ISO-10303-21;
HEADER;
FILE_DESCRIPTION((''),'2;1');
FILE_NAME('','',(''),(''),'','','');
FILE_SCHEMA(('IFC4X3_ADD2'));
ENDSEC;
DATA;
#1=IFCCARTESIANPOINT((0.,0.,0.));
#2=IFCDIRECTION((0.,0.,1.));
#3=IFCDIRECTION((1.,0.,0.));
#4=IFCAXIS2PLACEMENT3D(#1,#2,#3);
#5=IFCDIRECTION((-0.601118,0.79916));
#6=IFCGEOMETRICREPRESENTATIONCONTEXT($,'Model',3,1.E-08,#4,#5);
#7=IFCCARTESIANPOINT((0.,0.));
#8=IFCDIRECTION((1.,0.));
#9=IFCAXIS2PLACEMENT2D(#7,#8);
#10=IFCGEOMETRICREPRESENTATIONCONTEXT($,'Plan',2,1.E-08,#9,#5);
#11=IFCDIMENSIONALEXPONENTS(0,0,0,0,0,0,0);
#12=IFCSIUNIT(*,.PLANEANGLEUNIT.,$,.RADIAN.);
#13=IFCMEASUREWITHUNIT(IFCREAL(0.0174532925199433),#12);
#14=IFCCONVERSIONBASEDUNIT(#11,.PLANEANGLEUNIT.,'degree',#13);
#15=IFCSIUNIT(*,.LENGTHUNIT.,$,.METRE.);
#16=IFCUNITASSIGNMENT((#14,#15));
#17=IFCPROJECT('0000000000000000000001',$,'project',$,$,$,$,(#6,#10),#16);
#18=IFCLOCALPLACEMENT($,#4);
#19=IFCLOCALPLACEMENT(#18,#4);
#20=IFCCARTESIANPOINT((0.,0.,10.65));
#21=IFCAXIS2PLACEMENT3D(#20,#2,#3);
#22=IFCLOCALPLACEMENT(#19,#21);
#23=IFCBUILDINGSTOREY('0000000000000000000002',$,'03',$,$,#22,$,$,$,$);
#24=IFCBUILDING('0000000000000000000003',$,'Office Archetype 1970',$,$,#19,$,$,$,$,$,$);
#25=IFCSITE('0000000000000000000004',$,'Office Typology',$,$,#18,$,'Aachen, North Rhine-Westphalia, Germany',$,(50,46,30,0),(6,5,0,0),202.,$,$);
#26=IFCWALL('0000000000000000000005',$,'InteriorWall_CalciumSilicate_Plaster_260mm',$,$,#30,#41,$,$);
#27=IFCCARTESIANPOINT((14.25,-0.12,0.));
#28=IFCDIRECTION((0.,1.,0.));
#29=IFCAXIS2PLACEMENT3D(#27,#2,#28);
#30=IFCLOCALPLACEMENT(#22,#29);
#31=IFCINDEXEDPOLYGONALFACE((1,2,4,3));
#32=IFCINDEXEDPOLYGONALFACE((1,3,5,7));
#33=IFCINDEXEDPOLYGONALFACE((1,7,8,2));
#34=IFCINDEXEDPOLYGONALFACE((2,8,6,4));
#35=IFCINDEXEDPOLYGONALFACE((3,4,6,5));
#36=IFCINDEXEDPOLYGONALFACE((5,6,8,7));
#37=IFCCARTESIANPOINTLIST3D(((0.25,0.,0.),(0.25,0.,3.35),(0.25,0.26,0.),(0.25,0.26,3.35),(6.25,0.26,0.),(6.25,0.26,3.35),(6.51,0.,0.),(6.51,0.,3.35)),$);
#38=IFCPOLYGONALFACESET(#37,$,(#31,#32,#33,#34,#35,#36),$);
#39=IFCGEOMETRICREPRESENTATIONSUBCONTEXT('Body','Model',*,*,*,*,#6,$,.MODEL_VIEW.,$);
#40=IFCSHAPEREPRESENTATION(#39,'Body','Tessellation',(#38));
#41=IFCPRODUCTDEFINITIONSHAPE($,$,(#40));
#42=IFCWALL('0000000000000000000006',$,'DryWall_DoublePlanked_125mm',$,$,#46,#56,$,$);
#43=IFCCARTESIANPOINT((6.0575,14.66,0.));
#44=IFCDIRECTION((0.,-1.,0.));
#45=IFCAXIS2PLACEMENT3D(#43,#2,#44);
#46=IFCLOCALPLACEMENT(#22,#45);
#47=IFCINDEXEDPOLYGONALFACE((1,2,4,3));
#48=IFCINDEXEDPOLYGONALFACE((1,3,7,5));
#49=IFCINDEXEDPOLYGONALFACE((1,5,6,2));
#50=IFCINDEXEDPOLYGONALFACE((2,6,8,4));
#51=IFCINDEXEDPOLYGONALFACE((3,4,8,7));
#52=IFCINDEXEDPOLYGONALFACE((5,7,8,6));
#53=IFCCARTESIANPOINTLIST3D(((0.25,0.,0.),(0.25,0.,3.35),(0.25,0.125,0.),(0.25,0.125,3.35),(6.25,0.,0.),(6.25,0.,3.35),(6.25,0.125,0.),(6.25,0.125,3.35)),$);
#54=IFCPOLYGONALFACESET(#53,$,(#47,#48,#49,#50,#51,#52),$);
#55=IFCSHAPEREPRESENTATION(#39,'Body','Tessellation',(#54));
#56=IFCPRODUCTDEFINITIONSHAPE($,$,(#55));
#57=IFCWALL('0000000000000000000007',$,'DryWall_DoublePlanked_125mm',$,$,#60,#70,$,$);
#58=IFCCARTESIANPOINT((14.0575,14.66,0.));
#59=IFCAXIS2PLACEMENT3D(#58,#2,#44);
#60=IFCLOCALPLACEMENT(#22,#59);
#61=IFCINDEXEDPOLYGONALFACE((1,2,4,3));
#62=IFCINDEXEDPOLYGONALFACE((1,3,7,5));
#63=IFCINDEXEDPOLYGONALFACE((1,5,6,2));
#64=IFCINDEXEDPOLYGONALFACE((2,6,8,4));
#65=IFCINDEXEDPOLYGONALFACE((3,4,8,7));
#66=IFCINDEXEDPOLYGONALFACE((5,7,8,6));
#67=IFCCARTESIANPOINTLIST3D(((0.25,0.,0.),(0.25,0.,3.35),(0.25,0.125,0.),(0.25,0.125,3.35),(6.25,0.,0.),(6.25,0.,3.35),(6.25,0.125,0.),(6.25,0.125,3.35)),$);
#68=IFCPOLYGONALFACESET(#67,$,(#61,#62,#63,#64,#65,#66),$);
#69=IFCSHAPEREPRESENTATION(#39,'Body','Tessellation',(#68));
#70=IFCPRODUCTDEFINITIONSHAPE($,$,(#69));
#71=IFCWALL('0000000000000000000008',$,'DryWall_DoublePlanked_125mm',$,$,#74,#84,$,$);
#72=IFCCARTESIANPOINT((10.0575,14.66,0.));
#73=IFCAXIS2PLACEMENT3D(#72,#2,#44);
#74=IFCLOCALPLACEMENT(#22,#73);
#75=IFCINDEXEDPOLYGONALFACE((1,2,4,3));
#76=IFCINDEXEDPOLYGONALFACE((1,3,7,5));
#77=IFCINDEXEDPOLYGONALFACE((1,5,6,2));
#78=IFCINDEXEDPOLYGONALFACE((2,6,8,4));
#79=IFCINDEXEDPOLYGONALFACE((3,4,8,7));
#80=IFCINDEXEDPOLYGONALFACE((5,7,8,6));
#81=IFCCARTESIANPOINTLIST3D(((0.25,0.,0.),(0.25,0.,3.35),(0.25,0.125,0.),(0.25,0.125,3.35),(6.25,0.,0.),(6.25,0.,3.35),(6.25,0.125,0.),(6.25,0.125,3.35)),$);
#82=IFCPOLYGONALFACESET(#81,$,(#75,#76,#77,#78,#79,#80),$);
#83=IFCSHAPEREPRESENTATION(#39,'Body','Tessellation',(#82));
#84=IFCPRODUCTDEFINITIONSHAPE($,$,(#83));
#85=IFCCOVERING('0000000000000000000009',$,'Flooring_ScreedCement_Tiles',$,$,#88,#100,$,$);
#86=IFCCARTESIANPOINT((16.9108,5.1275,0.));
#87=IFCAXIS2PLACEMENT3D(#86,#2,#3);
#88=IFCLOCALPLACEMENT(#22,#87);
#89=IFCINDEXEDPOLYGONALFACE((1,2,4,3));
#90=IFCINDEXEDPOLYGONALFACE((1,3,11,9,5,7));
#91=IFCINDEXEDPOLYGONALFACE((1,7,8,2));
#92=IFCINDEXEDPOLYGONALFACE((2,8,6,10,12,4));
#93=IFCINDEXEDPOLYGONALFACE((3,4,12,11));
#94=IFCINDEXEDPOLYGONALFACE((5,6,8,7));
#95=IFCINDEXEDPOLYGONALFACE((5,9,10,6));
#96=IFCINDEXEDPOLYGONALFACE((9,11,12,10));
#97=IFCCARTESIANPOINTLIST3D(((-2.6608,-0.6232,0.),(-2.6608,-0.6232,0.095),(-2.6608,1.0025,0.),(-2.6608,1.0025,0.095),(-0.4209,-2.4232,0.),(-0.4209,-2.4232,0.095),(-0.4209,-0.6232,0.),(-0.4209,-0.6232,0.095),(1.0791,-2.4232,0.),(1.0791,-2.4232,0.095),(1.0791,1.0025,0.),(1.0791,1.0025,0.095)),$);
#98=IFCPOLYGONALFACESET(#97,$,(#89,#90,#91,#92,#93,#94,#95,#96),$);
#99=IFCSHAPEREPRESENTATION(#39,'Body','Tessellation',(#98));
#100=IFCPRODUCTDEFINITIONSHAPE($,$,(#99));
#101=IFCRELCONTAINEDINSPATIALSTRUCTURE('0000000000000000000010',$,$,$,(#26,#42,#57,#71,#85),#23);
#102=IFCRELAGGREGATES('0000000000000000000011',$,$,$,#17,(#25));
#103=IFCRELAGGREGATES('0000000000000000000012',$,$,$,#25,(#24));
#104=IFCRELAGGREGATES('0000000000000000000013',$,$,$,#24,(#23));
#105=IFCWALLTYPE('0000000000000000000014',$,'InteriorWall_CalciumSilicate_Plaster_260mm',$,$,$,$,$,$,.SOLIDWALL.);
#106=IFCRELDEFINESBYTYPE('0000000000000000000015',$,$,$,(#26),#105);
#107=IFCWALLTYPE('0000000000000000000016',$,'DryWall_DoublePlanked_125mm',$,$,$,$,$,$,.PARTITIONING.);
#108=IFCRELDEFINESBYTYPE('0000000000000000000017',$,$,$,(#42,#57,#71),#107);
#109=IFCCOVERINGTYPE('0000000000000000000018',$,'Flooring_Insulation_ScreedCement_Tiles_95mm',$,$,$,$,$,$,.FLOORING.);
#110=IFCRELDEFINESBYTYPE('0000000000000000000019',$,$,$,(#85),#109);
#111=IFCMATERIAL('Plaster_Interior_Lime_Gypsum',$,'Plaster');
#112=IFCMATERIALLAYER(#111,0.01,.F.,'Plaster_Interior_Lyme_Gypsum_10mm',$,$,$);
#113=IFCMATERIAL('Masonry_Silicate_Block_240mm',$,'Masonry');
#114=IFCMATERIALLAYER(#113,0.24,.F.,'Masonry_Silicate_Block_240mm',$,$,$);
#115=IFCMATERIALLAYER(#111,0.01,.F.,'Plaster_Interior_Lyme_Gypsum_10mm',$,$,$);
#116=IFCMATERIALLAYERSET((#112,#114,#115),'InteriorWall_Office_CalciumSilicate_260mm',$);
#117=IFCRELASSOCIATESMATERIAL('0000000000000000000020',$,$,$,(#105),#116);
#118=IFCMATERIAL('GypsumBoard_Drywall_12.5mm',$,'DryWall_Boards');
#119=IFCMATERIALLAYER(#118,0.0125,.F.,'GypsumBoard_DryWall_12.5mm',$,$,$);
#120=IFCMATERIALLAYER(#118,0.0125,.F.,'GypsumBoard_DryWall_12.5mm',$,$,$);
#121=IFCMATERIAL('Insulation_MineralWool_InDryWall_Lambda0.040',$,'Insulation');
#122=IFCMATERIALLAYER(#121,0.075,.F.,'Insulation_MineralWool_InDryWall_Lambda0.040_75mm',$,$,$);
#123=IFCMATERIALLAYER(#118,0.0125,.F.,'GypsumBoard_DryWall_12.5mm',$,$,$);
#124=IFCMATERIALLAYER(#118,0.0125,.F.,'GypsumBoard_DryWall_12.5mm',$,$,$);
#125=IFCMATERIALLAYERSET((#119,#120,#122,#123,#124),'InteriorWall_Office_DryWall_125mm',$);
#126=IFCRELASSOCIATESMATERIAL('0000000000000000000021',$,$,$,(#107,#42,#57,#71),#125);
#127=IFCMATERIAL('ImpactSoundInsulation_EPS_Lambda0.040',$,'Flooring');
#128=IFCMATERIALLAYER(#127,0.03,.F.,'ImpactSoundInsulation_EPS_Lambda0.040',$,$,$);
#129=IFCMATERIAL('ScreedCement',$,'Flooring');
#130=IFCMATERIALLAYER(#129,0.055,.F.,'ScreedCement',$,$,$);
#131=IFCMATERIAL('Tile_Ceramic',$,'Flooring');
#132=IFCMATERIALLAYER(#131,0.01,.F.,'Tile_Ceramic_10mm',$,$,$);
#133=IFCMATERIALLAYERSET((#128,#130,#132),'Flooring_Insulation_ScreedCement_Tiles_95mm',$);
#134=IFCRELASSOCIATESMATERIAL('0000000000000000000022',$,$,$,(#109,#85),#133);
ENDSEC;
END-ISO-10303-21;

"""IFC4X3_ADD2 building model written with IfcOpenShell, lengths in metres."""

from ifc_helpers import new_model, entity, si_unit, converted_unit, direction, frame, origin_with_axes, origin_2d_with_axis, place, context, subcontext, project, spatial, line, indexed_curve, outline, extrude, material, layer, layer_set, layer_usage, type_object, element, save


model = new_model("IFC4X3_ADD2")

# Units and contexts
model_context = context("Model", 3, precision=1e-08, world=origin_with_axes(), true_north=direction((-0.601118, 0.79916)))
plan_context = context("Plan", 2, precision=1e-08, world=origin_2d_with_axis(), true_north=direction((-0.601118, 0.79916)))
body_context = subcontext(model_context, "Body", "Model", "MODEL_VIEW")
ifc_project = project(units=[converted_unit("PLANEANGLEUNIT", "degree", entity("IfcReal", 0.0174532925199433), si_unit("PLANEANGLEUNIT", "RADIAN"), dimensions=[0, 0, 0, 0, 0, 0, 0]), si_unit("LENGTHUNIT", "METRE")], contexts=[model_context, plan_context])

# Site, building, storey
site_placement = place(None, origin_with_axes())
site = spatial("IfcSite", under=ifc_project, at=site_placement, Name="Office Typology", LongName="Aachen, North Rhine-Westphalia, Germany", RefLatitude=(50, 46, 30, 0), RefLongitude=(6, 5, 0, 0), RefElevation=202.0)
building_placement = place(site_placement, origin_with_axes())
building = spatial("IfcBuilding", under=site, at=building_placement, Name="Office Archetype 1970")
storey_placement = place(building_placement, frame((0.0, 0.0, 10.65), z_axis=(0.0, 0.0, 1.0), x_axis=(1.0, 0.0, 0.0)))
storey = spatial("IfcBuildingStorey", under=building, at=storey_placement, Name="03")

# Shared definitions
ifc_material_1 = material(Name="Plaster_Interior_Lime_Gypsum", Category="Plaster")
ifc_layer_1 = layer(ifc_material_1, 0.01, ventilated=False, Name="Plaster_Interior_Lyme_Gypsum_10mm")
ifc_material_2 = material(Name="Masonry_Silicate_Block_240mm", Category="Masonry")
ifc_layer_2 = layer(ifc_material_2, 0.24, ventilated=False, Name="Masonry_Silicate_Block_240mm")
ifc_layer_3 = layer(ifc_material_1, 0.01, ventilated=False, Name="Plaster_Interior_Lyme_Gypsum_10mm")
ifc_layer_set_1 = layer_set([ifc_layer_1, ifc_layer_2, ifc_layer_3], Name="InteriorWall_Office_CalciumSilicate_260mm")
wall_type_1 = type_object("IfcWallType", Name="InteriorWall_CalciumSilicate_Plaster_260mm", PredefinedType="SOLIDWALL", material=ifc_layer_set_1)

# Wall
wall_1_placement = place(storey_placement, frame((14.25, -0.12, 0.0), z_axis=(0.0, 0.0, 1.0), x_axis=(0.0, 1.0, 0.0)))
element("IfcWall", 1, at=wall_1_placement, inside=storey, type_object=wall_type_1, Name="InteriorWall_CalciumSilicate_Plaster_260mm", context=body_context, shape_type="SweptSolid", body=[
    extrude(outline(indexed_curve([(0.25, 0.0), (0.25, 0.26), (6.25, 0.26), (6.51, 0.0)], segments=[line(1, 2, 3, 4, 1)])), origin_with_axes(), (0.0, 0.0, 1.0), 3.35),
])

# Walls
ifc_material_3 = material(Name="GypsumBoard_Drywall_12.5mm", Category="DryWall_Boards")
ifc_layer_4 = layer(ifc_material_3, 0.0125, ventilated=False, Name="GypsumBoard_DryWall_12.5mm")
ifc_layer_5 = layer(ifc_material_3, 0.0125, ventilated=False, Name="GypsumBoard_DryWall_12.5mm")
ifc_material_4 = material(Name="Insulation_MineralWool_InDryWall_Lambda0.040", Category="Insulation")
ifc_layer_6 = layer(ifc_material_4, 0.075, ventilated=False, Name="Insulation_MineralWool_InDryWall_Lambda0.040_75mm")
ifc_layer_7 = layer(ifc_material_3, 0.0125, ventilated=False, Name="GypsumBoard_DryWall_12.5mm")
ifc_layer_8 = layer(ifc_material_3, 0.0125, ventilated=False, Name="GypsumBoard_DryWall_12.5mm")
ifc_layer_set_2 = layer_set([ifc_layer_4, ifc_layer_5, ifc_layer_6, ifc_layer_7, ifc_layer_8], Name="InteriorWall_Office_DryWall_125mm")
ifc_layer_usage_1 = layer_usage(ifc_layer_set_2, "AXIS2", "POSITIVE", 0.0)
wall_type_2 = type_object("IfcWallType", Name="DryWall_DoublePlanked_125mm", PredefinedType="PARTITIONING", material=ifc_layer_set_2)
wall_2_placement = place(storey_placement, frame((6.0575, 14.66, 0.0), z_axis=(0.0, 0.0, 1.0), x_axis=(0.0, -1.0, 0.0)))
element("IfcWall", 2, at=wall_2_placement, inside=storey, type_object=wall_type_2, material=ifc_layer_usage_1, Name="DryWall_DoublePlanked_125mm", context=body_context, shape_type="SweptSolid", body=[
    extrude(outline(indexed_curve([(0.25, 0.0), (0.25, 0.125), (6.25, 0.125), (6.25, 0.0)], segments=[line(1, 2, 3, 4, 1)])), origin_with_axes(), (0.0, 0.0, 1.0), 3.35),
])
ifc_layer_usage_2 = layer_usage(ifc_layer_set_2, "AXIS2", "POSITIVE", 0.0)
wall_3_placement = place(storey_placement, frame((14.0575, 14.66, 0.0), z_axis=(0.0, 0.0, 1.0), x_axis=(0.0, -1.0, 0.0)))
element("IfcWall", 3, at=wall_3_placement, inside=storey, type_object=wall_type_2, material=ifc_layer_usage_2, Name="DryWall_DoublePlanked_125mm", context=body_context, shape_type="SweptSolid", body=[
    extrude(outline(indexed_curve([(0.25, 0.0), (0.25, 0.125), (6.25, 0.125), (6.25, 0.0)], segments=[line(1, 2, 3, 4, 1)])), origin_with_axes(), (0.0, 0.0, 1.0), 3.35),
])
ifc_layer_usage_3 = layer_usage(ifc_layer_set_2, "AXIS2", "POSITIVE", 0.0)
wall_4_placement = place(storey_placement, frame((10.0575, 14.66, 0.0), z_axis=(0.0, 0.0, 1.0), x_axis=(0.0, -1.0, 0.0)))
element("IfcWall", 4, at=wall_4_placement, inside=storey, type_object=wall_type_2, material=ifc_layer_usage_3, Name="DryWall_DoublePlanked_125mm", context=body_context, shape_type="SweptSolid", body=[
    extrude(outline(indexed_curve([(0.25, 0.0), (0.25, 0.125), (6.25, 0.125), (6.25, 0.0)], segments=[line(1, 2, 3, 4, 1)])), origin_with_axes(), (0.0, 0.0, 1.0), 3.35),
])

# Covering
ifc_material_5 = material(Name="ImpactSoundInsulation_EPS_Lambda0.040", Category="Flooring")
ifc_layer_9 = layer(ifc_material_5, 0.03, ventilated=False, Name="ImpactSoundInsulation_EPS_Lambda0.040")
ifc_material_6 = material(Name="ScreedCement", Category="Flooring")
ifc_layer_10 = layer(ifc_material_6, 0.055, ventilated=False, Name="ScreedCement")
ifc_material_7 = material(Name="Tile_Ceramic", Category="Flooring")
ifc_layer_11 = layer(ifc_material_7, 0.01, ventilated=False, Name="Tile_Ceramic_10mm")
ifc_layer_set_3 = layer_set([ifc_layer_9, ifc_layer_10, ifc_layer_11], Name="Flooring_Insulation_ScreedCement_Tiles_95mm")
ifc_layer_usage_4 = layer_usage(ifc_layer_set_3, "AXIS3", "POSITIVE", 0.0)
covering_type = type_object("IfcCoveringType", Name="Flooring_Insulation_ScreedCement_Tiles_95mm", PredefinedType="FLOORING", material=ifc_layer_set_3)
covering_placement = place(storey_placement, frame((16.9108, 5.1275, 0.0), z_axis=(0.0, 0.0, 1.0), x_axis=(1.0, 0.0, 0.0)))
element("IfcCovering", 5, at=covering_placement, inside=storey, type_object=covering_type, material=ifc_layer_usage_4, Name="Flooring_ScreedCement_Tiles", context=body_context, shape_type="SweptSolid", body=[
    extrude(outline(indexed_curve([(-2.6608, 1.0025), (-2.6608, -0.6232), (-0.4209, -0.6232), (-0.4209, -2.4232), (1.0791, -2.4232), (1.0791, 1.0025)], segments=[line(1, 2, 3, 4, 5, 6, 1)])), None, (0.0, 0.0, 1.0), 0.095),
])

save(model, "model.ifc")
